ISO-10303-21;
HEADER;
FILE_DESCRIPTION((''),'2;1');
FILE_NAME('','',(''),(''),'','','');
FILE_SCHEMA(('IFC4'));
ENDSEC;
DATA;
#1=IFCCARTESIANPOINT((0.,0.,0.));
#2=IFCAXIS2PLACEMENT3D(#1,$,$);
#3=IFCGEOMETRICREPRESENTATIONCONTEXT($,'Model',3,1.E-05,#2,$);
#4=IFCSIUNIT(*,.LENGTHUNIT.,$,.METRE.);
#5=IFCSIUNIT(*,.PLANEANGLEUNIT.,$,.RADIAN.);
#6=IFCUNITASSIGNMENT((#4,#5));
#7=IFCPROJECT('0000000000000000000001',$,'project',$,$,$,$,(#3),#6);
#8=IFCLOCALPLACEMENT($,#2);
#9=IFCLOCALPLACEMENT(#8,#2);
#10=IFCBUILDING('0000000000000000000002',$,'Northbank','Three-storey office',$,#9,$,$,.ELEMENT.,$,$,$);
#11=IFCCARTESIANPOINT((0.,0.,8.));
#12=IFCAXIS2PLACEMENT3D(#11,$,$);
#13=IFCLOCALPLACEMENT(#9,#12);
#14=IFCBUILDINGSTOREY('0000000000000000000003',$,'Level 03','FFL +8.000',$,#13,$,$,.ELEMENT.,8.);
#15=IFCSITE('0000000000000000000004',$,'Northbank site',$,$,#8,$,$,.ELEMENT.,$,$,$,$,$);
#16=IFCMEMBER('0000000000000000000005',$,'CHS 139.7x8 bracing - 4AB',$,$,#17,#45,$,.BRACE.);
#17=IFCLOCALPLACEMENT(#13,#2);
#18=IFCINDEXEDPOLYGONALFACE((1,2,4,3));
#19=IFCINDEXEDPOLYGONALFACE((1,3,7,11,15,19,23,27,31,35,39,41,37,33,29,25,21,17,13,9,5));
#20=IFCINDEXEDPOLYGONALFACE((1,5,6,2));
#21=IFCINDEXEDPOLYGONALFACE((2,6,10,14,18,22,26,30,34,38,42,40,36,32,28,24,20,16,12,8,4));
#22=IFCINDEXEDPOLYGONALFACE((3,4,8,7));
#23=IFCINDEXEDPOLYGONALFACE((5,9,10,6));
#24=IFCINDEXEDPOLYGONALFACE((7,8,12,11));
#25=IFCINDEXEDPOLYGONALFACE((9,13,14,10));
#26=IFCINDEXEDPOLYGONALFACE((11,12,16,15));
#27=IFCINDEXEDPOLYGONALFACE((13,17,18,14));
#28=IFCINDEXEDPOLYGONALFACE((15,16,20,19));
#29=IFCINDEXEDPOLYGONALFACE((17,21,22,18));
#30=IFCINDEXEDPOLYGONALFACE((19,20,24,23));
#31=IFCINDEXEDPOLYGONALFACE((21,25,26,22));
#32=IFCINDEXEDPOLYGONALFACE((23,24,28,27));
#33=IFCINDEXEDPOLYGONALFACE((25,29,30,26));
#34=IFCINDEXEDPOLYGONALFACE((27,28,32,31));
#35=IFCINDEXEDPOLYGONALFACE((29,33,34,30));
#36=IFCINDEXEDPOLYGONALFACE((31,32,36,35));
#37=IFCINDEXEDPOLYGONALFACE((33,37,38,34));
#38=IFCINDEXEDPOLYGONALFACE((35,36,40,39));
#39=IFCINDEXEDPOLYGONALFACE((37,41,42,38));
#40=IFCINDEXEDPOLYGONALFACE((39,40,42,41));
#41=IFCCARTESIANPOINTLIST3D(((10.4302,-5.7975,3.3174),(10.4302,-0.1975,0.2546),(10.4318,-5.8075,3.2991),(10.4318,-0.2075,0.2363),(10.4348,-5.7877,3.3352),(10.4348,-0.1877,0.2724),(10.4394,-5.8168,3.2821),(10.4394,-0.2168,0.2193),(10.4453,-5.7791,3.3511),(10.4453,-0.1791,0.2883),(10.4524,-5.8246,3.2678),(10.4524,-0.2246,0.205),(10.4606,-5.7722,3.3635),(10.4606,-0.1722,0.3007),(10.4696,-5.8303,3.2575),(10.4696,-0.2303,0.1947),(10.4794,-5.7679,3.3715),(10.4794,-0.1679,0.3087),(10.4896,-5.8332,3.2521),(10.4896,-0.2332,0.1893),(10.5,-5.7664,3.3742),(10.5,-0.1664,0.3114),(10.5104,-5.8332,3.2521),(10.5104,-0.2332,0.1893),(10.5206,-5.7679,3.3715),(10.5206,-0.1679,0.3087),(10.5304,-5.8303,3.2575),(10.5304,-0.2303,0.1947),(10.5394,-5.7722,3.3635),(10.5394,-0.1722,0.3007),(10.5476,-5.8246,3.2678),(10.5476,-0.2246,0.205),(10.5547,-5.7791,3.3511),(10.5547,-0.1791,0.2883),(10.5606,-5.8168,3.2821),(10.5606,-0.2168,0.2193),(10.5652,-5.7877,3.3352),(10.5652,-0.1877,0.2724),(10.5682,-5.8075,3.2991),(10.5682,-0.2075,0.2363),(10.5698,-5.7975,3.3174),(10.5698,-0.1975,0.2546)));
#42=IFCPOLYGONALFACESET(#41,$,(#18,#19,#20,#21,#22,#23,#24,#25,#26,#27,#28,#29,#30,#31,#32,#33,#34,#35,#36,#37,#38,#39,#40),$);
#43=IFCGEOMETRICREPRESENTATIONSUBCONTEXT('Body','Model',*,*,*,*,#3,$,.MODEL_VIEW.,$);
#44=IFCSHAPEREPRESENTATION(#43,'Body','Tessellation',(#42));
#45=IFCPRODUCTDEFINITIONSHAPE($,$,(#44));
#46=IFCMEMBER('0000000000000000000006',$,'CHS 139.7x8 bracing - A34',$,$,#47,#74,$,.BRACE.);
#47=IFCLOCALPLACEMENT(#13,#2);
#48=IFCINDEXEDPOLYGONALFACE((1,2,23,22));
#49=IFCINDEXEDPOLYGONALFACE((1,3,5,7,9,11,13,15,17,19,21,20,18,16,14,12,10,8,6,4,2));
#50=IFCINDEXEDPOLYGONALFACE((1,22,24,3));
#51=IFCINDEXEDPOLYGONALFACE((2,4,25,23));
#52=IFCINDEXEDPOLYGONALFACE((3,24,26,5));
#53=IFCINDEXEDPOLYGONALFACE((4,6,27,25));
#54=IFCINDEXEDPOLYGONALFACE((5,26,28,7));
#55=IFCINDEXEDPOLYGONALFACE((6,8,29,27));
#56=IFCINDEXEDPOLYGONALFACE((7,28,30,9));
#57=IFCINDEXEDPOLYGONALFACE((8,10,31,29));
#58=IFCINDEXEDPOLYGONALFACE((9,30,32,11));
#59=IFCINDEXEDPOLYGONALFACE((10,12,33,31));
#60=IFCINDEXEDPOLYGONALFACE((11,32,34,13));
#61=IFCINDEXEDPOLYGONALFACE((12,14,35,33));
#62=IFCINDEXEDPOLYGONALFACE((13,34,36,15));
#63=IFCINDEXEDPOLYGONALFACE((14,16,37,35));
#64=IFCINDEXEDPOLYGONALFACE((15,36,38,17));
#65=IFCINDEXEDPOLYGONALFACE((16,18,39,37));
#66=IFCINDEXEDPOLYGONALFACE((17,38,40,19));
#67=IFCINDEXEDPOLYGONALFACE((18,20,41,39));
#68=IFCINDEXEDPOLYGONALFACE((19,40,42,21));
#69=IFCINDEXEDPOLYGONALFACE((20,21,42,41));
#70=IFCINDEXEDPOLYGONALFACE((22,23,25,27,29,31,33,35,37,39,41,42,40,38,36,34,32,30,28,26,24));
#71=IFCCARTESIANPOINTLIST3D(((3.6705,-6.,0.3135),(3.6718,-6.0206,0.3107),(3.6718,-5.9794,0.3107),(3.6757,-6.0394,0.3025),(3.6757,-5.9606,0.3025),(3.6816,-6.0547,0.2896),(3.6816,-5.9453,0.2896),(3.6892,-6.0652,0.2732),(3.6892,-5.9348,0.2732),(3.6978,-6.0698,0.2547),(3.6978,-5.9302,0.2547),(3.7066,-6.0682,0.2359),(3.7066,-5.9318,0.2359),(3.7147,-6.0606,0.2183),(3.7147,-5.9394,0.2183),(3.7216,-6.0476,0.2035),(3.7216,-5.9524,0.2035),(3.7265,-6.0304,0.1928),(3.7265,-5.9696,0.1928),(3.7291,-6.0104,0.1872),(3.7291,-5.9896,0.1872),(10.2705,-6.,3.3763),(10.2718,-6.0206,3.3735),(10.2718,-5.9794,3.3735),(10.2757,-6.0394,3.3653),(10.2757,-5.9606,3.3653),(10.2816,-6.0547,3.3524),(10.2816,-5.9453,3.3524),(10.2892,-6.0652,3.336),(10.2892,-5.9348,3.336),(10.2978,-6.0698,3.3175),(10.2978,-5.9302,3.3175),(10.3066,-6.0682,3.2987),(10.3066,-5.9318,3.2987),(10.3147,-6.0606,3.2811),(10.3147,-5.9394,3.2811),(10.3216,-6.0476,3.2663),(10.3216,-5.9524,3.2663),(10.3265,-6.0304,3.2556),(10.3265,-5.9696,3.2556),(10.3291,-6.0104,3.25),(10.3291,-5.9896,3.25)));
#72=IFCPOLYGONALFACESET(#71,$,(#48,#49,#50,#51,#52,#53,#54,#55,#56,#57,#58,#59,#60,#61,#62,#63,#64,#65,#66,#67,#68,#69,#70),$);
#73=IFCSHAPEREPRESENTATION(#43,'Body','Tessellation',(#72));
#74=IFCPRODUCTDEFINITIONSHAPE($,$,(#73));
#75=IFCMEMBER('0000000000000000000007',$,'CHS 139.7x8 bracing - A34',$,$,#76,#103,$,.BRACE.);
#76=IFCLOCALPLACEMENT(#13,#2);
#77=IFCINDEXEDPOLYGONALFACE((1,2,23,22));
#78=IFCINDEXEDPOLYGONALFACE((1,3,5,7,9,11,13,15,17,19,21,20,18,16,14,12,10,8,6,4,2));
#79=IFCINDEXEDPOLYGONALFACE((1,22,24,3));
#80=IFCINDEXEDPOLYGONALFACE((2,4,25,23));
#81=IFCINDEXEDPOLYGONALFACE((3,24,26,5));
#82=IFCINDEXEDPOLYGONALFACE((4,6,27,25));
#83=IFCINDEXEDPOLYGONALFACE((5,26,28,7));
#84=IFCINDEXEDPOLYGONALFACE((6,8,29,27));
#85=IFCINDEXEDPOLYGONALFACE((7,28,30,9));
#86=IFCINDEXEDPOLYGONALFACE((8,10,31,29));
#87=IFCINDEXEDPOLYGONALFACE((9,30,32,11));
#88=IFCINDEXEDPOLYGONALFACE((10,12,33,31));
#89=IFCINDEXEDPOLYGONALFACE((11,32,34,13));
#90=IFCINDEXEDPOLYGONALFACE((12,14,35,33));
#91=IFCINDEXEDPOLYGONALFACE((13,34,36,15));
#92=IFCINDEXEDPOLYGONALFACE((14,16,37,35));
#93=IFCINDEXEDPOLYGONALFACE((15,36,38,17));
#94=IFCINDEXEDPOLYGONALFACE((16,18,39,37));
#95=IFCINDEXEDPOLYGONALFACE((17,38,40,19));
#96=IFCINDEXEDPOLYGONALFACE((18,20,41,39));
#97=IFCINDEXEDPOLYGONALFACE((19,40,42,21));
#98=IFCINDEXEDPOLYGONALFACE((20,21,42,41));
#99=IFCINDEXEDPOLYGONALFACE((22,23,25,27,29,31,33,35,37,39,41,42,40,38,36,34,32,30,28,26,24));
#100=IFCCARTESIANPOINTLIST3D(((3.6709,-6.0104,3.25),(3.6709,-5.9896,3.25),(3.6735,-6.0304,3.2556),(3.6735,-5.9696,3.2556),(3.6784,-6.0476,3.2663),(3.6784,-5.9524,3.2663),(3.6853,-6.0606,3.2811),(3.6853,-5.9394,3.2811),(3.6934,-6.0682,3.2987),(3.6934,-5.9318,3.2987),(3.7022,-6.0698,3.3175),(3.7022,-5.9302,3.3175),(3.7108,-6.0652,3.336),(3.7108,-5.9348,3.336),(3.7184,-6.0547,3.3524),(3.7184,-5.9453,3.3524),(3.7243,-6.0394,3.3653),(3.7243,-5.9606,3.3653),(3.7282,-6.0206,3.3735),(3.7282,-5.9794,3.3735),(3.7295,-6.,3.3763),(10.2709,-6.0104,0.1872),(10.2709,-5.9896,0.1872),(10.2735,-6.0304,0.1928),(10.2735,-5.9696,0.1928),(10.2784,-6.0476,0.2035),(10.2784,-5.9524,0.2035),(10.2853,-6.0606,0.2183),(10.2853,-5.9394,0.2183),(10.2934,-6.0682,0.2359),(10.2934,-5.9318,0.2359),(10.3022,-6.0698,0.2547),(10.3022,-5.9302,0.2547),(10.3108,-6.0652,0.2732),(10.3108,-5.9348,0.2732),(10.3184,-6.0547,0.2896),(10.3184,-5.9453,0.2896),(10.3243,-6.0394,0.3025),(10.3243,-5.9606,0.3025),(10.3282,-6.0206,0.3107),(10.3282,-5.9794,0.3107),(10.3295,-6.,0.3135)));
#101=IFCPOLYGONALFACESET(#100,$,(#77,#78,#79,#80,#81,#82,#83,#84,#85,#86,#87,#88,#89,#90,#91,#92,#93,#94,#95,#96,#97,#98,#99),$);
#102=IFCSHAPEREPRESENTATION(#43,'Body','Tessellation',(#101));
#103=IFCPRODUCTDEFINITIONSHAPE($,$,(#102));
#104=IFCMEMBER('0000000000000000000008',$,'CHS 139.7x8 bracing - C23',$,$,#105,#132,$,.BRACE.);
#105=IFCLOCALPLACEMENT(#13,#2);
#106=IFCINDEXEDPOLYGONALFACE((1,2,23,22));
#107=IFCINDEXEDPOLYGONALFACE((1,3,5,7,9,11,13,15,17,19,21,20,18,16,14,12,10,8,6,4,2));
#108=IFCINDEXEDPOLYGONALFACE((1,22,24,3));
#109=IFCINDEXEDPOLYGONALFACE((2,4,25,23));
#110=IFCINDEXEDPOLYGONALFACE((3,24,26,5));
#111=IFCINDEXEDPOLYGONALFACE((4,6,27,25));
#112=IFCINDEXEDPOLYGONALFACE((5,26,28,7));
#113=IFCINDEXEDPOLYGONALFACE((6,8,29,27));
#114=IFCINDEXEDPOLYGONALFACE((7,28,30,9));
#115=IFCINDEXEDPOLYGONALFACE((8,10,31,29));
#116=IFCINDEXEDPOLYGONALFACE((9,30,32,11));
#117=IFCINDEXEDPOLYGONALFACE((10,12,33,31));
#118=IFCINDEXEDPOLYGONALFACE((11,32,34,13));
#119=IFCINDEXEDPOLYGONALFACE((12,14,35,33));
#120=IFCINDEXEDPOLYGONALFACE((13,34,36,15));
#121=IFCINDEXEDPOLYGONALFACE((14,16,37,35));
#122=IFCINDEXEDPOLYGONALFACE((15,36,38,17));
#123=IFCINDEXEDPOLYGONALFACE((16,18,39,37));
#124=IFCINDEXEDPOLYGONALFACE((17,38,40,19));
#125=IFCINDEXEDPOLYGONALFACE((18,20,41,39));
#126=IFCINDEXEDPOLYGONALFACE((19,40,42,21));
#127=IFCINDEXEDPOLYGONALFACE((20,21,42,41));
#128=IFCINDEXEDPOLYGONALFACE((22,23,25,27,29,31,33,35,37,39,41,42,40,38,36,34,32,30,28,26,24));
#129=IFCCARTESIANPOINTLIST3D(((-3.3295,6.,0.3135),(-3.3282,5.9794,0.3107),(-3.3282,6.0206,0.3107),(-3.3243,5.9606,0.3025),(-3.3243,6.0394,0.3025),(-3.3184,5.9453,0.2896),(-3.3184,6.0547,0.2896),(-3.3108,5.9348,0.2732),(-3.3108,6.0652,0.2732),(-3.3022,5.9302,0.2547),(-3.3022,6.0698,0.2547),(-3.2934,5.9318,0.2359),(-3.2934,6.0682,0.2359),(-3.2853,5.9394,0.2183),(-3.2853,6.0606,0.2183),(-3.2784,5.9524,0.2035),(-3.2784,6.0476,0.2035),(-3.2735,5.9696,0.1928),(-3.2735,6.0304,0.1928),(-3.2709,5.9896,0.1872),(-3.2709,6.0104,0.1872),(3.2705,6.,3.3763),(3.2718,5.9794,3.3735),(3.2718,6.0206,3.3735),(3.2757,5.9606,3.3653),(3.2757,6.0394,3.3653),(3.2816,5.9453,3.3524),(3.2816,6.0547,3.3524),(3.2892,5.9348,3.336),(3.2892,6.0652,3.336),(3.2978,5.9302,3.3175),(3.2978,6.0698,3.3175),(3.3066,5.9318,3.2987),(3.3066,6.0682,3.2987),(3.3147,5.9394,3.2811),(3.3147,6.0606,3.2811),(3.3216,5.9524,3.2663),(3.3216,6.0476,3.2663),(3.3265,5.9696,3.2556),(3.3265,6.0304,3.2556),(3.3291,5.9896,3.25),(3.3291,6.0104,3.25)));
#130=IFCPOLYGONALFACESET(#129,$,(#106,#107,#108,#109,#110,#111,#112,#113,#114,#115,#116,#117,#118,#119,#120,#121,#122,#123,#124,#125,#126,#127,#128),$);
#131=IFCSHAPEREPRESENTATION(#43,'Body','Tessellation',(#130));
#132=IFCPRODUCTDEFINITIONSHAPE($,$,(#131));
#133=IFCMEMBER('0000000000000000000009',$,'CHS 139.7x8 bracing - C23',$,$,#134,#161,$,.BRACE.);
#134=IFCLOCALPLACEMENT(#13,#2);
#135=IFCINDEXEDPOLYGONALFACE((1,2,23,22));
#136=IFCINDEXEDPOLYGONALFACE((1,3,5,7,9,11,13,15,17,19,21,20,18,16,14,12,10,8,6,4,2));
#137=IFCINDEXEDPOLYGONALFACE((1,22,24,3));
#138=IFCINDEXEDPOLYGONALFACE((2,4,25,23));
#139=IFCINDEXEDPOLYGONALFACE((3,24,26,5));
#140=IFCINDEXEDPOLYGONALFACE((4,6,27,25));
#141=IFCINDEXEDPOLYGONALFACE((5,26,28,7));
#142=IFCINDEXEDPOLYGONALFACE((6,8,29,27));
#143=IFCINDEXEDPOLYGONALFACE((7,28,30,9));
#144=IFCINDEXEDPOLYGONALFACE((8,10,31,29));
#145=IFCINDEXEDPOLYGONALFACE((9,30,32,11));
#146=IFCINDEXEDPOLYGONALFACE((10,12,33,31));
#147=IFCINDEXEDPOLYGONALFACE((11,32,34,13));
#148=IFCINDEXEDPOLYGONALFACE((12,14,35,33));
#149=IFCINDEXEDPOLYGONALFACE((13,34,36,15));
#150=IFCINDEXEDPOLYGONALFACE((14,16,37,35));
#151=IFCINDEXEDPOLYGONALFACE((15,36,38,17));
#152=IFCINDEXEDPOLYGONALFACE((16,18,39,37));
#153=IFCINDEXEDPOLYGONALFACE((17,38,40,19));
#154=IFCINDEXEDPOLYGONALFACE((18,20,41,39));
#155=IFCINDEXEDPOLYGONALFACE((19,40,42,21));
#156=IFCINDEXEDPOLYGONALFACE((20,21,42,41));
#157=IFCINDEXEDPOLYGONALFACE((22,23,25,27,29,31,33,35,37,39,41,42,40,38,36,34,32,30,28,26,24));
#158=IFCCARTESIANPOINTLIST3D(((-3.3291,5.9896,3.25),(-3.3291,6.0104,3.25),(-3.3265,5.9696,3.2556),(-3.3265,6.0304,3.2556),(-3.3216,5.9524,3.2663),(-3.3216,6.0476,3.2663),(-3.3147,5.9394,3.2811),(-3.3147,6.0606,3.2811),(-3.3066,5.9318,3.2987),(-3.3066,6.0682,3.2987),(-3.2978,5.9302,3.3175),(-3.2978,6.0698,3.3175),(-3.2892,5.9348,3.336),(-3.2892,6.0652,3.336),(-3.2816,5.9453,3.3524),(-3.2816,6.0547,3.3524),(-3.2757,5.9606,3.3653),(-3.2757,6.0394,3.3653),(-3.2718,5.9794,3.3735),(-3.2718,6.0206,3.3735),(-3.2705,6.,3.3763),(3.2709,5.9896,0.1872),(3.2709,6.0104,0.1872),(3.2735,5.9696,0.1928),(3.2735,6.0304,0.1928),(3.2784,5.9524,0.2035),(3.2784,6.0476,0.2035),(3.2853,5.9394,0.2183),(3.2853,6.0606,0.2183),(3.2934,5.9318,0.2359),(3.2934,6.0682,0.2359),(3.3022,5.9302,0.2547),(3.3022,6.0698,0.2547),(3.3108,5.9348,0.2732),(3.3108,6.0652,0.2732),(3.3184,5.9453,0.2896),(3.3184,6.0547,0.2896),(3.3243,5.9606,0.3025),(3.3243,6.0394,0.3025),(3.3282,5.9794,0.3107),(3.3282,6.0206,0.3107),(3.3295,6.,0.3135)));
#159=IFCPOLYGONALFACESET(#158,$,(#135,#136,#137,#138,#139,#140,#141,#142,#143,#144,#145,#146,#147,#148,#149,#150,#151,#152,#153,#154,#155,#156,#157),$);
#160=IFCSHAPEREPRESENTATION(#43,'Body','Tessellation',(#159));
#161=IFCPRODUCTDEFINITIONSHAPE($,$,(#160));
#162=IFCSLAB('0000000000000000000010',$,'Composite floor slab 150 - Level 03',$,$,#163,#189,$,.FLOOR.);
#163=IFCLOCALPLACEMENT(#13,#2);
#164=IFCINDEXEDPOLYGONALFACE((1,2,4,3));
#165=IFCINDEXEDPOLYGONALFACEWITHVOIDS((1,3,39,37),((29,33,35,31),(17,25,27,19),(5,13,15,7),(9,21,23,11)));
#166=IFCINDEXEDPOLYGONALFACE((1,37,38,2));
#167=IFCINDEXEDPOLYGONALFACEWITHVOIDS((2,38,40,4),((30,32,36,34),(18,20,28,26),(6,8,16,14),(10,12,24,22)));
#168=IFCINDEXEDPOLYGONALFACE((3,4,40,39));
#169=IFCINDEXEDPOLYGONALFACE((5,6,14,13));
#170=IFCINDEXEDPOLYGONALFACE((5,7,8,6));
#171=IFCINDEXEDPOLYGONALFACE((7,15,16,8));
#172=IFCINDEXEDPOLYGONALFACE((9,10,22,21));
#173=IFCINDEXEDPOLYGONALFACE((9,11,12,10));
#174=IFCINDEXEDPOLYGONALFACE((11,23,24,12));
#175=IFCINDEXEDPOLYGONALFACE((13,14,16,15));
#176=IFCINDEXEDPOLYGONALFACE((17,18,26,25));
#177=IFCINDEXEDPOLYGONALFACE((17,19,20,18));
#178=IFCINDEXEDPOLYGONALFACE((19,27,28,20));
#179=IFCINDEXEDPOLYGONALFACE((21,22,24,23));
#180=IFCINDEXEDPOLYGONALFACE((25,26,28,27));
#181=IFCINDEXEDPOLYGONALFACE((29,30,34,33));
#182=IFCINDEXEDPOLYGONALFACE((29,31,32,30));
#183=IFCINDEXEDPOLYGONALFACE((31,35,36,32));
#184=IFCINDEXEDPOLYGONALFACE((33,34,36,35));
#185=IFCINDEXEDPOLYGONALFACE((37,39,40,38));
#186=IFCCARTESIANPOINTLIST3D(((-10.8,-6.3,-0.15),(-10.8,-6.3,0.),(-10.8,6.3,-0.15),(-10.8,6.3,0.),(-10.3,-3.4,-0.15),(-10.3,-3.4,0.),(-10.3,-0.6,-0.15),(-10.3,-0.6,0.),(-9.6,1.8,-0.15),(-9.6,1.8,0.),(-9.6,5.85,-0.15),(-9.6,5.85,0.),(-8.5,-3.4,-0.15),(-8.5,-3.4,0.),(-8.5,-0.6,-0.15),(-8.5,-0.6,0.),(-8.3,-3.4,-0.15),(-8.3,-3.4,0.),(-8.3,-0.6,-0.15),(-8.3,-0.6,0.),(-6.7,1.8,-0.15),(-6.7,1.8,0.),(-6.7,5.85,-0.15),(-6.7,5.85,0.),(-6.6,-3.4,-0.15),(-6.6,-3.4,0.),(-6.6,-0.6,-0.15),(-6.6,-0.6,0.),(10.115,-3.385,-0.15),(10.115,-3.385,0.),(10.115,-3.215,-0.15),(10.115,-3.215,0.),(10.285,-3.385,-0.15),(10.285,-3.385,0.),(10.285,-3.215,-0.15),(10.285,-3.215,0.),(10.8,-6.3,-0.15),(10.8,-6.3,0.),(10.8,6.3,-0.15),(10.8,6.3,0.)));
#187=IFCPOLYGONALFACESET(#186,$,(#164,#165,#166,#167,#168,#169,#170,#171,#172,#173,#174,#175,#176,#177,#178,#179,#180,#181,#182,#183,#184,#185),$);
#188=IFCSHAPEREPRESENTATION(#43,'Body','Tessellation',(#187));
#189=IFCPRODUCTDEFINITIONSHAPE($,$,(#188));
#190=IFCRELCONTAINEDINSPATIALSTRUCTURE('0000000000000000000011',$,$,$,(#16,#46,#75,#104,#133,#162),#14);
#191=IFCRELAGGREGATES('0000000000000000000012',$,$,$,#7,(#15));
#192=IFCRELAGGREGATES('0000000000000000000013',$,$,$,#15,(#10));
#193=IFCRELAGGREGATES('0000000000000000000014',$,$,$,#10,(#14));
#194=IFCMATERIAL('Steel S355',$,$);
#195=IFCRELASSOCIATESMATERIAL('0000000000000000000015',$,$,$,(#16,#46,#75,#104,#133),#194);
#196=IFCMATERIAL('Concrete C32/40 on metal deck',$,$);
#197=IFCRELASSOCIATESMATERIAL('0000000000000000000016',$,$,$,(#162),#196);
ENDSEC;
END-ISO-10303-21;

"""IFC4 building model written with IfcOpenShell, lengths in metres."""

from ifc_helpers import new_model, si_unit, frame, origin, place, context, subcontext, project, spatial, polyline, circle, outline, extrude, material, element, save


model = new_model("IFC4")

# Units and contexts
model_context = context("Model", 3, precision=1e-05, world=origin())
body_context = subcontext(model_context, "Body", "Model", "MODEL_VIEW")
ifc_project = project(units=[si_unit("LENGTHUNIT", "METRE"), si_unit("PLANEANGLEUNIT", "RADIAN")], contexts=[model_context])

# Site, building, storey
site_placement = place(None, origin())
site = spatial("IfcSite", under=ifc_project, at=site_placement, Name="Northbank site", CompositionType="ELEMENT")
building_placement = place(site_placement, origin())
building = spatial("IfcBuilding", under=site, at=building_placement, Name="Northbank", Description="Three-storey office", CompositionType="ELEMENT")
storey_placement = place(building_placement, frame((0.0, 0.0, 8.0)))
storey = spatial("IfcBuildingStorey", under=building, at=storey_placement, Name="Level 03", Description="FFL +8.000", CompositionType="ELEMENT", Elevation=8.0)

# Shared definitions
ifc_material_1 = material(Name="Steel S355")

# Members
member_1_placement = place(storey_placement, frame((0.0, 0.0, -8.0)))
element("IfcMember", 1, at=member_1_placement, inside=storey, material=ifc_material_1, Name="CHS 139.7x8 bracing - 4AB", PredefinedType="BRACE", context=body_context, shape_type="SweptSolid", body=[
    extrude(circle(Radius=0.07), frame((10.5, -0.2, 8.25), z_axis=(0.0, -0.877351, 0.479849), x_axis=(0.0, 0.479849, 0.877351)), (0.0, 0.0, 1.0), 6.3828),
])
member_2_placement = place(storey_placement, frame((0.0, 0.0, -8.0)))
element("IfcMember", 2, at=member_2_placement, inside=storey, material=ifc_material_1, Name="CHS 139.7x8 bracing - A34", PredefinedType="BRACE", context=body_context, shape_type="SweptSolid", body=[
    extrude(circle(Radius=0.07), frame((3.7, -6.0, 8.25), z_axis=(0.907087, 0.0, 0.420943), x_axis=(-0.420943, 0.0, 0.907087)), (0.0, 0.0, 1.0), 7.276),
])
member_3_placement = place(storey_placement, frame((0.0, 0.0, -8.0)))
element("IfcMember", 3, at=member_3_placement, inside=storey, material=ifc_material_1, Name="CHS 139.7x8 bracing - A34", PredefinedType="BRACE", context=body_context, shape_type="SweptSolid", body=[
    extrude(circle(Radius=0.07), frame((10.3, -6.0, 8.25), z_axis=(-0.907087, 0.0, 0.420943), x_axis=(0.420943, 0.0, 0.907087)), (0.0, 0.0, 1.0), 7.276),
])
member_4_placement = place(storey_placement, frame((0.0, 0.0, -8.0)))
element("IfcMember", 4, at=member_4_placement, inside=storey, material=ifc_material_1, Name="CHS 139.7x8 bracing - C23", PredefinedType="BRACE", context=body_context, shape_type="SweptSolid", body=[
    extrude(circle(Radius=0.07), frame((-3.3, 6.0, 8.25), z_axis=(0.907087, 0.0, 0.420943), x_axis=(-0.420943, 0.0, 0.907087)), (0.0, 0.0, 1.0), 7.276),
])
member_5_placement = place(storey_placement, frame((0.0, 0.0, -8.0)))
element("IfcMember", 5, at=member_5_placement, inside=storey, material=ifc_material_1, Name="CHS 139.7x8 bracing - C23", PredefinedType="BRACE", context=body_context, shape_type="SweptSolid", body=[
    extrude(circle(Radius=0.07), frame((3.3, 6.0, 8.25), z_axis=(-0.907087, 0.0, 0.420943), x_axis=(0.420943, 0.0, 0.907087)), (0.0, 0.0, 1.0), 7.276),
])

# Slab
ifc_material_2 = material(Name="Concrete C32/40 on metal deck")
slab_placement = place(storey_placement, frame((0.0, 0.0, -8.0)))
element("IfcSlab", 6, at=slab_placement, inside=storey, material=ifc_material_2, Name="Composite floor slab 150 - Level 03", PredefinedType="FLOOR", context=body_context, shape_type="SweptSolid", body=[
    extrude(outline(polyline([(-10.8, -6.3), (10.8, -6.3), (10.8, 6.3), (-10.8, 6.3), (-10.8, -6.3)]), holes=[polyline([(-10.3, -3.4), (-10.3, -0.6), (-8.5, -0.6), (-8.5, -3.4), (-10.3, -3.4)]), polyline([(-8.3, -3.4), (-8.3, -0.6), (-6.6, -0.6), (-6.6, -3.4), (-8.3, -3.4)]), polyline([(-9.6, 1.8), (-9.6, 5.85), (-6.7, 5.85), (-6.7, 1.8), (-9.6, 1.8)]), polyline([(10.115, -3.385), (10.115, -3.215), (10.285, -3.215), (10.285, -3.385), (10.115, -3.385)])]), frame((0.0, 0.0, 7.85)), (0.0, 0.0, 1.0), 0.15),
])

save(model, "model.ifc")
